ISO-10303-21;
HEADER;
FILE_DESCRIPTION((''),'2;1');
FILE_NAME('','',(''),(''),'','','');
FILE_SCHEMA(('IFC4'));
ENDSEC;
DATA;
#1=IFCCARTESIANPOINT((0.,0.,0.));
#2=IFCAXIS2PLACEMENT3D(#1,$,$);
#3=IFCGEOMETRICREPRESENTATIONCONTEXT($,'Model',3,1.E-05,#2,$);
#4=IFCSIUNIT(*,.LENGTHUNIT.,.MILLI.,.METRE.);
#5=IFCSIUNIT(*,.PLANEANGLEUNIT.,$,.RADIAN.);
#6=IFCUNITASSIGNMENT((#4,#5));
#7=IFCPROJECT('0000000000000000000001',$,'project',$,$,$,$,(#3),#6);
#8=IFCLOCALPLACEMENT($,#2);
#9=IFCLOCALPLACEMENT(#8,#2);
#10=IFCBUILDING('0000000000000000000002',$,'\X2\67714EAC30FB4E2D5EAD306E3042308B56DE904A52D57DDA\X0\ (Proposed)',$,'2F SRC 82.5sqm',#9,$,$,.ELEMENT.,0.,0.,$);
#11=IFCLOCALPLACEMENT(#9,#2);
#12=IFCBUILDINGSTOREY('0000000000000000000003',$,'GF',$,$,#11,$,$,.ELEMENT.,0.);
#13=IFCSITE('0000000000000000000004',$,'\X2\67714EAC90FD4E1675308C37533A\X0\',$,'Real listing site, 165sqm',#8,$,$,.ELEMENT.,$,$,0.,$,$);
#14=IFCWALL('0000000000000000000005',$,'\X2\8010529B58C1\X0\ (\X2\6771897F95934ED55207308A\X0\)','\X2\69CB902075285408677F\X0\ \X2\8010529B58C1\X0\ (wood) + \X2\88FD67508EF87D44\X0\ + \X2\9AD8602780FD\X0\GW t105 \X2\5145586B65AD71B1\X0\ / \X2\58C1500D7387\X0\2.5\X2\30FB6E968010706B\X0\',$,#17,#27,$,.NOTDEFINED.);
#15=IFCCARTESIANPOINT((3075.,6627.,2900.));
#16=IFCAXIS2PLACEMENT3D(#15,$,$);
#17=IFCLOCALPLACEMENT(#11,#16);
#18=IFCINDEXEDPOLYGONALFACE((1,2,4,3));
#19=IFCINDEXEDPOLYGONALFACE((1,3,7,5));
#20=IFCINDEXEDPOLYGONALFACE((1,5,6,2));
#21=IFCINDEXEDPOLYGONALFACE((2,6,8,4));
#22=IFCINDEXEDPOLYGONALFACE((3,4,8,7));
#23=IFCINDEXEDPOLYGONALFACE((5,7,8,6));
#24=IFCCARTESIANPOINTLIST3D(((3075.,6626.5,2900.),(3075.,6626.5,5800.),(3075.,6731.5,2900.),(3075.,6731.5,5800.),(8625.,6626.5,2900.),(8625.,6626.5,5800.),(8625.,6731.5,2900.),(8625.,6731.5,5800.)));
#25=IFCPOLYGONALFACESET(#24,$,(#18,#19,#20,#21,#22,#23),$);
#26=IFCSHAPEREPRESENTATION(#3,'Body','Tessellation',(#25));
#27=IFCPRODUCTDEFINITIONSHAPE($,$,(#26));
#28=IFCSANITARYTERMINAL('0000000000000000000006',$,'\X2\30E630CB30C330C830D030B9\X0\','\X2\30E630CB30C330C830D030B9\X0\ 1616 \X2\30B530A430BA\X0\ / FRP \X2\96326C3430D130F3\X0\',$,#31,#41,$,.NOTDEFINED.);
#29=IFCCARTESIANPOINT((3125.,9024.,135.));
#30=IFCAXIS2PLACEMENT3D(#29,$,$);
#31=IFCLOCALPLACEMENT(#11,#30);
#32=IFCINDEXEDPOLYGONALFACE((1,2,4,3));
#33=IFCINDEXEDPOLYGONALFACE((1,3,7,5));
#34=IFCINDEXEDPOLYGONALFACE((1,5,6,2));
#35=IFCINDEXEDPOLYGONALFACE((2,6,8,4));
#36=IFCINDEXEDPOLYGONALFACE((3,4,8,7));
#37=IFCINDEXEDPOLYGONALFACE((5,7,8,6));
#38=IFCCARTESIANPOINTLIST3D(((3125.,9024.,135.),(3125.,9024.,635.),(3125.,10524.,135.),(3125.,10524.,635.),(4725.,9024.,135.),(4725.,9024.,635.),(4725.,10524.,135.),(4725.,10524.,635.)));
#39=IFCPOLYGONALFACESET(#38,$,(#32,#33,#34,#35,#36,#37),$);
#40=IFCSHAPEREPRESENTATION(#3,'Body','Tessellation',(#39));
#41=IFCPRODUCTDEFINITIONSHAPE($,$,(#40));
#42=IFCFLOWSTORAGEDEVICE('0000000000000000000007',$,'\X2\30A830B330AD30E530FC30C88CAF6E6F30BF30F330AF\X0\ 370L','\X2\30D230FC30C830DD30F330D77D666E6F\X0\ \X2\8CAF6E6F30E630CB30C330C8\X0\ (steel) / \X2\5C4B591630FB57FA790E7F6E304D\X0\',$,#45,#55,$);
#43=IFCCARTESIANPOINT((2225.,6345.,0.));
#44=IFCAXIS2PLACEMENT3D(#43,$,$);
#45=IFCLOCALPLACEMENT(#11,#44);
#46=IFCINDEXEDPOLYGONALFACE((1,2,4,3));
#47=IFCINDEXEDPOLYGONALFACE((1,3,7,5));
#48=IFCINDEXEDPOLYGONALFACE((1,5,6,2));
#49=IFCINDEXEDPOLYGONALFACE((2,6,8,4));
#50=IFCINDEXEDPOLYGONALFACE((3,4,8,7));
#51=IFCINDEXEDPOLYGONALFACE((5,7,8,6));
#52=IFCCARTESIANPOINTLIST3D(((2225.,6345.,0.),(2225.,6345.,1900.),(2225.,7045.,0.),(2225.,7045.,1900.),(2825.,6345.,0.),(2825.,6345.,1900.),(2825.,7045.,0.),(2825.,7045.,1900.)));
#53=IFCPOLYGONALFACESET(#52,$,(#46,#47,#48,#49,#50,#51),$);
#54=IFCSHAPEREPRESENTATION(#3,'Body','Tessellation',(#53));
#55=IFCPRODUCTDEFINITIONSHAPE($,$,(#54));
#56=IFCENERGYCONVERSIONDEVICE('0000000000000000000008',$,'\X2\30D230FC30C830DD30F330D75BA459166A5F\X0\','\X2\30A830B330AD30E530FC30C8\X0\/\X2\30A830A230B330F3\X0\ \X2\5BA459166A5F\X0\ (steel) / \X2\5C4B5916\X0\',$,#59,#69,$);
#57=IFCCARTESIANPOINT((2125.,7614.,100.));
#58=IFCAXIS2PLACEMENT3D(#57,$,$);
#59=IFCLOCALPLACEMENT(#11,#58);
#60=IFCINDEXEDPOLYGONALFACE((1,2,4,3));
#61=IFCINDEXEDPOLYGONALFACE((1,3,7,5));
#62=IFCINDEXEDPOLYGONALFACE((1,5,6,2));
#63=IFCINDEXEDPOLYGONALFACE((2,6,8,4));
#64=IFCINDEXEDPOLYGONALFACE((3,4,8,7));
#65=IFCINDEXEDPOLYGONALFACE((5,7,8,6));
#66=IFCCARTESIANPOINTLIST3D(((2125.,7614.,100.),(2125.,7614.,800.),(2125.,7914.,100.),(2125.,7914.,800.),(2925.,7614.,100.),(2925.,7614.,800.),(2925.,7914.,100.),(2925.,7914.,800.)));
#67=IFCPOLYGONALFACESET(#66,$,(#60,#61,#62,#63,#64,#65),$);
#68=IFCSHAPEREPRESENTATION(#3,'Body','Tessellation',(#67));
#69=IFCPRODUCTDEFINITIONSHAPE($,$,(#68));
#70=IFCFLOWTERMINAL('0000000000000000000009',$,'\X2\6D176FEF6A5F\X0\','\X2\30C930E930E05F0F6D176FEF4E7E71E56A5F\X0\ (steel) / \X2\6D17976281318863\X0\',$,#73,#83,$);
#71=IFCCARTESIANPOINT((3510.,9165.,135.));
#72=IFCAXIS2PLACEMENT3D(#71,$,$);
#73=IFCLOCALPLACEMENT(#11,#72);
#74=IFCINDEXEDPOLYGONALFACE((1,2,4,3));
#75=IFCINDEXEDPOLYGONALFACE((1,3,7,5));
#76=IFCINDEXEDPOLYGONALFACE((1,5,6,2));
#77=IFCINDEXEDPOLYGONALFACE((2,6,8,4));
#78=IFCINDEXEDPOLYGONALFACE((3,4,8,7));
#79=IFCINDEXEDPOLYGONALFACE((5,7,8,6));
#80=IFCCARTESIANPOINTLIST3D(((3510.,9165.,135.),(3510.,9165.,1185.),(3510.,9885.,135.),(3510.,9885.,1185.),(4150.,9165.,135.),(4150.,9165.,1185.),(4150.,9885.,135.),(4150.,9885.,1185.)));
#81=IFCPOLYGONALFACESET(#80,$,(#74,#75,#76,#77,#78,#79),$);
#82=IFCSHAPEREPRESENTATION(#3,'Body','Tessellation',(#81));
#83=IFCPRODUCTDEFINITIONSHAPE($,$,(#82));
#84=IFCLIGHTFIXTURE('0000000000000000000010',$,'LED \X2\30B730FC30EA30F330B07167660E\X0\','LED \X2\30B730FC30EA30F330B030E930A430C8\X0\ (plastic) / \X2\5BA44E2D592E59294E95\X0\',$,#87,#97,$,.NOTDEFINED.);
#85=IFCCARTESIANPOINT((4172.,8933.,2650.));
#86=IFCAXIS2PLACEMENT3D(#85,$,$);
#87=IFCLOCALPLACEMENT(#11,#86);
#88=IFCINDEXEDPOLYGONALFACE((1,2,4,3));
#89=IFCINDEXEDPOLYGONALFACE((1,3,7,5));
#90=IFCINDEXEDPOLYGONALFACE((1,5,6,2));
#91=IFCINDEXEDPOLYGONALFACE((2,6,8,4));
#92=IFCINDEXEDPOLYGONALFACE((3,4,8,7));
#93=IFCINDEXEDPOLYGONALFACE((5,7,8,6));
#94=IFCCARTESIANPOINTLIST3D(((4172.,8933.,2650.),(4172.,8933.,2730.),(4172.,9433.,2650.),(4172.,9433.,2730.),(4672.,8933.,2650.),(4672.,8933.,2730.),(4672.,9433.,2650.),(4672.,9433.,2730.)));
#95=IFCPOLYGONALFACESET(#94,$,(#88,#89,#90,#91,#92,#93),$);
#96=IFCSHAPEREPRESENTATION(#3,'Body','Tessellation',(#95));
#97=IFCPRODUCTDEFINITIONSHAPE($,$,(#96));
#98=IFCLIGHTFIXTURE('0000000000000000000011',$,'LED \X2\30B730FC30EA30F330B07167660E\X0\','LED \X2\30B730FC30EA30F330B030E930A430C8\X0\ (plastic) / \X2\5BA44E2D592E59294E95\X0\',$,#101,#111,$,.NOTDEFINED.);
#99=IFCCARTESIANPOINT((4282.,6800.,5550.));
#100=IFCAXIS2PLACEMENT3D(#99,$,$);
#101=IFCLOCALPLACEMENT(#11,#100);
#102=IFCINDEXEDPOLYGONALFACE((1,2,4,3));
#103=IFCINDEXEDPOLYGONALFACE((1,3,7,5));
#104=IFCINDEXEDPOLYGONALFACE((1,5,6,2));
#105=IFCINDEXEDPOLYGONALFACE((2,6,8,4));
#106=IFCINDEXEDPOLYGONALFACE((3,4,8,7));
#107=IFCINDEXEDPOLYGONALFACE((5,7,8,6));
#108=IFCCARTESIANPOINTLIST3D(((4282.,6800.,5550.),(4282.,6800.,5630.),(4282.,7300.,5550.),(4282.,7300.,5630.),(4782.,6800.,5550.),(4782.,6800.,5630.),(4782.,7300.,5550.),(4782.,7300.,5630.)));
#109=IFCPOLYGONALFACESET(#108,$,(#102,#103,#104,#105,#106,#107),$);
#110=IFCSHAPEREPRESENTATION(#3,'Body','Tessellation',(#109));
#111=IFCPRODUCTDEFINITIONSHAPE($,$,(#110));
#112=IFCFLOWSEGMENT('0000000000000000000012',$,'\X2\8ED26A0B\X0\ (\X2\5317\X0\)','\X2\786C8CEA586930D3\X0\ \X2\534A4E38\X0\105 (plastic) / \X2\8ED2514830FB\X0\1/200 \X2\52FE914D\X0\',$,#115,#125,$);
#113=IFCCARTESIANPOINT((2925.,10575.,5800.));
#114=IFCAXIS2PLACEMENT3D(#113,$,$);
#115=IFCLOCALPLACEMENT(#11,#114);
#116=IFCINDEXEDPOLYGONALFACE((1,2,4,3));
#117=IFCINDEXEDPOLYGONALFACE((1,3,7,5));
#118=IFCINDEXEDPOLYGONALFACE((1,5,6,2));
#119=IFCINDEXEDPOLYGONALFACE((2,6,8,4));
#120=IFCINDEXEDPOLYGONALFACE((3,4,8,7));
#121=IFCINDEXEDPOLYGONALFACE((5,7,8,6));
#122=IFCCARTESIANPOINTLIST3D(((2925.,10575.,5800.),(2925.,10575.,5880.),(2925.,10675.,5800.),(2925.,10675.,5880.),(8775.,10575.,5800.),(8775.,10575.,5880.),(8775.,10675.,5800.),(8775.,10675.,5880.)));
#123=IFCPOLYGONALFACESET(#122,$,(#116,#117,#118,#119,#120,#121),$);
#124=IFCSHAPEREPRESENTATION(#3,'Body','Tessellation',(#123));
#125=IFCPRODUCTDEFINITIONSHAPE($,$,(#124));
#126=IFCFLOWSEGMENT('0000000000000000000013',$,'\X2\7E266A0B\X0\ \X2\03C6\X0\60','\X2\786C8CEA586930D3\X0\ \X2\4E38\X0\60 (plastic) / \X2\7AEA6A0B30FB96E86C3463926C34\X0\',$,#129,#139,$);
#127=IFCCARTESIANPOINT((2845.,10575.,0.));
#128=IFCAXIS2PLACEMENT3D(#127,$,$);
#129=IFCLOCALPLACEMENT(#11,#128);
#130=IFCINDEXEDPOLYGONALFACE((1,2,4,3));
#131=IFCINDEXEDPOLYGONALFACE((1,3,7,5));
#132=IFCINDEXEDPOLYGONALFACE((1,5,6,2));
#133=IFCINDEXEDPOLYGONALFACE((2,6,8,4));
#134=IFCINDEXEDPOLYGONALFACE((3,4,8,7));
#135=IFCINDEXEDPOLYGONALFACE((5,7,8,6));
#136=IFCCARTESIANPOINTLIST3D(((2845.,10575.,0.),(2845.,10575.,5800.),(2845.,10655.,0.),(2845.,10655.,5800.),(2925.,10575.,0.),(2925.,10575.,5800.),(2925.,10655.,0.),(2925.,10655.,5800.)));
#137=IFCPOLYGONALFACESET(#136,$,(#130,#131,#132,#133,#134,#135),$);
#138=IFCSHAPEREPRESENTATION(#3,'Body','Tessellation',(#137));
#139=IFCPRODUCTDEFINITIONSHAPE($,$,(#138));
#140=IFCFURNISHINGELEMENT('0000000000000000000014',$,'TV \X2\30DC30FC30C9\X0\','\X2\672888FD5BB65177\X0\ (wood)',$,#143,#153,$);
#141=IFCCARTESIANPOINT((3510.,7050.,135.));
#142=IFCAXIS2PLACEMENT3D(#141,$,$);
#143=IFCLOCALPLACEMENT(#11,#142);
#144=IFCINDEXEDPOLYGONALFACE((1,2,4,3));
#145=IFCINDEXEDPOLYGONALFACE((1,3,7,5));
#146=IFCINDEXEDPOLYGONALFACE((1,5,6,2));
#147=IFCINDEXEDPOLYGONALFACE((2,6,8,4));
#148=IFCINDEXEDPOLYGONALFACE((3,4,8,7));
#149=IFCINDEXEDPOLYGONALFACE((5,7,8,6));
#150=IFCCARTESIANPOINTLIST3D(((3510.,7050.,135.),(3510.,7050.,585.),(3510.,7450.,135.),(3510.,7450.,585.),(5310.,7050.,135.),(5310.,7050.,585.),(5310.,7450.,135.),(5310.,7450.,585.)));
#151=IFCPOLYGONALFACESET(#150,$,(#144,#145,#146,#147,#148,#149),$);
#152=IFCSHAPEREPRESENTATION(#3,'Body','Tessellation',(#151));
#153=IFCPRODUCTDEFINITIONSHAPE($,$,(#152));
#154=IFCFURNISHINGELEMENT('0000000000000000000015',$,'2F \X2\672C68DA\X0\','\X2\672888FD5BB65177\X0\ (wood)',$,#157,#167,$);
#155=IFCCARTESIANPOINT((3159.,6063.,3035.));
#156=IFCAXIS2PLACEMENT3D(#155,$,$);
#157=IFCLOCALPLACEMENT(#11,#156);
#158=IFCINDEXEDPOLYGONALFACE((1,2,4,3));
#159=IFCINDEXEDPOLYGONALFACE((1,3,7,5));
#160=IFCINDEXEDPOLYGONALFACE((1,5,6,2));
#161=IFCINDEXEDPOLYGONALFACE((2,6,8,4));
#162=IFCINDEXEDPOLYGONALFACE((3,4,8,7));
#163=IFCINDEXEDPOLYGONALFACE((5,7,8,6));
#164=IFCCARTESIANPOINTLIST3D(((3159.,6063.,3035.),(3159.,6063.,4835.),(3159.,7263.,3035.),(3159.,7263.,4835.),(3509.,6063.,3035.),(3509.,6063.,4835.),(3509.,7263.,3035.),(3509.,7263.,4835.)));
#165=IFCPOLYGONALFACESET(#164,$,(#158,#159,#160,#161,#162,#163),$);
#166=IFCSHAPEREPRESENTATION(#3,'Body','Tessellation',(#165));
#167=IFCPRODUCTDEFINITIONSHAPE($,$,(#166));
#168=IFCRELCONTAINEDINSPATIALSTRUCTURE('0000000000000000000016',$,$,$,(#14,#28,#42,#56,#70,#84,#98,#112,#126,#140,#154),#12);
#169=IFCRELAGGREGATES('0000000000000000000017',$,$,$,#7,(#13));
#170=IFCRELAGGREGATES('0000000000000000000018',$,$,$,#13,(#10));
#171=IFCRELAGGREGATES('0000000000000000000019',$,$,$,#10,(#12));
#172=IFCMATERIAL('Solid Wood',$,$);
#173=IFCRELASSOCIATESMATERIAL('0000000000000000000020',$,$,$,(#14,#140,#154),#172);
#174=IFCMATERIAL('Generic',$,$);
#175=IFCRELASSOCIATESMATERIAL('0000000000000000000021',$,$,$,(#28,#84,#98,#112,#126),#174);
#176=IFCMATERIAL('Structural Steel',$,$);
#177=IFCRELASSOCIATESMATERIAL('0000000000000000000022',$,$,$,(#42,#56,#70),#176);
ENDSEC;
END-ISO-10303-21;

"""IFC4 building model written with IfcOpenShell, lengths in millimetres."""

from ifc_helpers import new_model, si_unit, frame, frame_2d, origin, place, context, project, spatial, rectangle, extrude, material, element, save


model = new_model("IFC4")

# Units and contexts
model_context = context("Model", 3, precision=1e-05, world=origin())
ifc_project = project(units=[si_unit("LENGTHUNIT", "METRE", prefix="MILLI"), si_unit("PLANEANGLEUNIT", "RADIAN")], contexts=[model_context])

# Site, building, storey
site_placement = place(None, origin())
site = spatial("IfcSite", under=ifc_project, at=site_placement, Name="東京都世田谷区", ObjectType="Real listing site, 165sqm", CompositionType="ELEMENT", RefElevation=0.0)
building_placement = place(site_placement, origin())
building = spatial("IfcBuilding", under=site, at=building_placement, Name="東京・中庭のある回遊動線 (Proposed)", ObjectType="2F SRC 82.5sqm", CompositionType="ELEMENT", ElevationOfRefHeight=0.0, ElevationOfTerrain=0.0)
storey_placement = place(building_placement, origin())
storey = spatial("IfcBuildingStorey", under=building, at=storey_placement, Name="GF", CompositionType="ELEMENT", Elevation=0.0)

# Shared definitions
ifc_material_1 = material(Name="Solid Wood")

# Wall
wall_1_placement = place(storey_placement, frame((3075.0, 6627.0, 2900.0)))
element("IfcWall", 1, at=wall_1_placement, inside=storey, material=ifc_material_1, Name="耐力壁 (東西間仕切り)", Description="構造用合板 耐力壁 (wood) + 製材軸組 + 高性能GW t105 充填断熱 / 壁倍率2.5・準耐火", PredefinedType="NOTDEFINED", context=model_context, shape_type="SweptSolid", body=[
    extrude(rectangle(XDim=5550.0, YDim=105.0, at=frame_2d((2775.0, 52.0))), frame((3075.0, 6627.0, 2900.0)), (0.0, 0.0, 1.0), 2900.0),
])

# Sanitary terminal
ifc_material_2 = material(Name="Generic")
sanitary_terminal_placement = place(storey_placement, frame((3125.0, 9024.0, 135.0)))
element("IfcSanitaryTerminal", 2, at=sanitary_terminal_placement, inside=storey, material=ifc_material_2, Name="ユニットバス", Description="ユニットバス 1616 サイズ / FRP 防水パン", PredefinedType="NOTDEFINED", context=model_context, shape_type="SweptSolid", body=[
    extrude(rectangle(XDim=1600.0, YDim=1500.0, at=frame_2d((800.0, 750.0))), frame((3125.0, 9024.0, 135.0)), (0.0, 0.0, 1.0), 500.0),
])

# Flow storage device
ifc_material_3 = material(Name="Structural Steel")
flow_storage_device_placement = place(storey_placement, frame((2225.0, 6345.0, 0.0)))
element("IfcFlowStorageDevice", 3, at=flow_storage_device_placement, inside=storey, material=ifc_material_3, Name="エコキュート貯湯タンク 370L", Description="ヒートポンプ給湯 貯湯ユニット (steel) / 屋外・基礎置き", context=model_context, shape_type="SweptSolid", body=[
    extrude(rectangle(XDim=600.0, YDim=700.0, at=frame_2d((300.0, 350.0))), frame((2225.0, 6345.0, 0.0)), (0.0, 0.0, 1.0), 1900.0),
])

# Energy conversion device
energy_conversion_device_placement = place(storey_placement, frame((2125.0, 7614.0, 100.0)))
element("IfcEnergyConversionDevice", 4, at=energy_conversion_device_placement, inside=storey, material=ifc_material_3, Name="ヒートポンプ室外機", Description="エコキュート/エアコン 室外機 (steel) / 屋外", context=model_context, shape_type="SweptSolid", body=[
    extrude(rectangle(XDim=800.0, YDim=300.0, at=frame_2d((400.0, 150.0))), frame((2125.0, 7614.0, 100.0)), (0.0, 0.0, 1.0), 700.0),
])

# Flow terminal
flow_terminal_placement = place(storey_placement, frame((3510.0, 9165.0, 135.0)))
element("IfcFlowTerminal", 5, at=flow_terminal_placement, inside=storey, material=ifc_material_3, Name="洗濯機", Description="ドラム式洗濯乾燥機 (steel) / 洗面脱衣", context=model_context, shape_type="SweptSolid", body=[
    extrude(rectangle(XDim=640.0, YDim=720.0, at=frame_2d((320.0, 360.0))), frame((3510.0, 9165.0, 135.0)), (0.0, 0.0, 1.0), 1050.0),
])

# Light fixtures
light_fixture_1_placement = place(storey_placement, frame((4172.0, 8933.0, 2650.0)))
element("IfcLightFixture", 6, at=light_fixture_1_placement, inside=storey, material=ifc_material_2, Name="LED シーリング照明", Description="LED シーリングライト (plastic) / 室中央天井", PredefinedType="NOTDEFINED", context=model_context, shape_type="SweptSolid", body=[
    extrude(rectangle(XDim=500.0, YDim=500.0, at=frame_2d((250.0, 250.0))), frame((4172.0, 8933.0, 2650.0)), (0.0, 0.0, 1.0), 80.0),
])
light_fixture_2_placement = place(storey_placement, frame((4282.0, 6800.0, 5550.0)))
element("IfcLightFixture", 7, at=light_fixture_2_placement, inside=storey, material=ifc_material_2, Name="LED シーリング照明", Description="LED シーリングライト (plastic) / 室中央天井", PredefinedType="NOTDEFINED", context=model_context, shape_type="SweptSolid", body=[
    extrude(rectangle(XDim=500.0, YDim=500.0, at=frame_2d((250.0, 250.0))), frame((4282.0, 6800.0, 5550.0)), (0.0, 0.0, 1.0), 80.0),
])

# Flow segments
flow_segment_1_placement = place(storey_placement, frame((2925.0, 10575.0, 5800.0)))
element("IfcFlowSegment", 8, at=flow_segment_1_placement, inside=storey, material=ifc_material_2, Name="軒樋 (北)", Description="硬質塩ビ 半丸105 (plastic) / 軒先・1/200 勾配", context=model_context, shape_type="SweptSolid", body=[
    extrude(rectangle(XDim=5850.0, YDim=100.0, at=frame_2d((2925.0, 50.0))), frame((2925.0, 10575.0, 5800.0)), (0.0, 0.0, 1.0), 80.0),
])
flow_segment_2_placement = place(storey_placement, frame((2845.0, 10575.0, 0.0)))
element("IfcFlowSegment", 9, at=flow_segment_2_placement, inside=storey, material=ifc_material_2, Name="縦樋 φ60", Description="硬質塩ビ 丸60 (plastic) / 竪樋・雨水排水", context=model_context, shape_type="SweptSolid", body=[
    extrude(rectangle(XDim=80.0, YDim=80.0, at=frame_2d((40.0, 40.0))), frame((2845.0, 10575.0, 0.0)), (0.0, 0.0, 1.0), 5800.0),
])

# Furnishing elements
furnishing_1_placement = place(storey_placement, frame((3510.0, 7050.0, 135.0)))
element("IfcFurnishingElement", 10, at=furnishing_1_placement, inside=storey, material=ifc_material_1, Name="TV ボード", Description="木製家具 (wood)", context=model_context, shape_type="SweptSolid", body=[
    extrude(rectangle(XDim=1800.0, YDim=400.0, at=frame_2d((900.0, 200.0))), frame((3510.0, 7050.0, 135.0)), (0.0, 0.0, 1.0), 450.0),
])
furnishing_2_placement = place(storey_placement, frame((3159.0, 6063.0, 3035.0)))
element("IfcFurnishingElement", 11, at=furnishing_2_placement, inside=storey, material=ifc_material_1, Name="2F 本棚", Description="木製家具 (wood)", context=model_context, shape_type="SweptSolid", body=[
    extrude(rectangle(XDim=350.0, YDim=1200.0, at=frame_2d((175.0, 600.0))), frame((3159.0, 6063.0, 3035.0)), (0.0, 0.0, 1.0), 1800.0),
])

save(model, "model.ifc")
